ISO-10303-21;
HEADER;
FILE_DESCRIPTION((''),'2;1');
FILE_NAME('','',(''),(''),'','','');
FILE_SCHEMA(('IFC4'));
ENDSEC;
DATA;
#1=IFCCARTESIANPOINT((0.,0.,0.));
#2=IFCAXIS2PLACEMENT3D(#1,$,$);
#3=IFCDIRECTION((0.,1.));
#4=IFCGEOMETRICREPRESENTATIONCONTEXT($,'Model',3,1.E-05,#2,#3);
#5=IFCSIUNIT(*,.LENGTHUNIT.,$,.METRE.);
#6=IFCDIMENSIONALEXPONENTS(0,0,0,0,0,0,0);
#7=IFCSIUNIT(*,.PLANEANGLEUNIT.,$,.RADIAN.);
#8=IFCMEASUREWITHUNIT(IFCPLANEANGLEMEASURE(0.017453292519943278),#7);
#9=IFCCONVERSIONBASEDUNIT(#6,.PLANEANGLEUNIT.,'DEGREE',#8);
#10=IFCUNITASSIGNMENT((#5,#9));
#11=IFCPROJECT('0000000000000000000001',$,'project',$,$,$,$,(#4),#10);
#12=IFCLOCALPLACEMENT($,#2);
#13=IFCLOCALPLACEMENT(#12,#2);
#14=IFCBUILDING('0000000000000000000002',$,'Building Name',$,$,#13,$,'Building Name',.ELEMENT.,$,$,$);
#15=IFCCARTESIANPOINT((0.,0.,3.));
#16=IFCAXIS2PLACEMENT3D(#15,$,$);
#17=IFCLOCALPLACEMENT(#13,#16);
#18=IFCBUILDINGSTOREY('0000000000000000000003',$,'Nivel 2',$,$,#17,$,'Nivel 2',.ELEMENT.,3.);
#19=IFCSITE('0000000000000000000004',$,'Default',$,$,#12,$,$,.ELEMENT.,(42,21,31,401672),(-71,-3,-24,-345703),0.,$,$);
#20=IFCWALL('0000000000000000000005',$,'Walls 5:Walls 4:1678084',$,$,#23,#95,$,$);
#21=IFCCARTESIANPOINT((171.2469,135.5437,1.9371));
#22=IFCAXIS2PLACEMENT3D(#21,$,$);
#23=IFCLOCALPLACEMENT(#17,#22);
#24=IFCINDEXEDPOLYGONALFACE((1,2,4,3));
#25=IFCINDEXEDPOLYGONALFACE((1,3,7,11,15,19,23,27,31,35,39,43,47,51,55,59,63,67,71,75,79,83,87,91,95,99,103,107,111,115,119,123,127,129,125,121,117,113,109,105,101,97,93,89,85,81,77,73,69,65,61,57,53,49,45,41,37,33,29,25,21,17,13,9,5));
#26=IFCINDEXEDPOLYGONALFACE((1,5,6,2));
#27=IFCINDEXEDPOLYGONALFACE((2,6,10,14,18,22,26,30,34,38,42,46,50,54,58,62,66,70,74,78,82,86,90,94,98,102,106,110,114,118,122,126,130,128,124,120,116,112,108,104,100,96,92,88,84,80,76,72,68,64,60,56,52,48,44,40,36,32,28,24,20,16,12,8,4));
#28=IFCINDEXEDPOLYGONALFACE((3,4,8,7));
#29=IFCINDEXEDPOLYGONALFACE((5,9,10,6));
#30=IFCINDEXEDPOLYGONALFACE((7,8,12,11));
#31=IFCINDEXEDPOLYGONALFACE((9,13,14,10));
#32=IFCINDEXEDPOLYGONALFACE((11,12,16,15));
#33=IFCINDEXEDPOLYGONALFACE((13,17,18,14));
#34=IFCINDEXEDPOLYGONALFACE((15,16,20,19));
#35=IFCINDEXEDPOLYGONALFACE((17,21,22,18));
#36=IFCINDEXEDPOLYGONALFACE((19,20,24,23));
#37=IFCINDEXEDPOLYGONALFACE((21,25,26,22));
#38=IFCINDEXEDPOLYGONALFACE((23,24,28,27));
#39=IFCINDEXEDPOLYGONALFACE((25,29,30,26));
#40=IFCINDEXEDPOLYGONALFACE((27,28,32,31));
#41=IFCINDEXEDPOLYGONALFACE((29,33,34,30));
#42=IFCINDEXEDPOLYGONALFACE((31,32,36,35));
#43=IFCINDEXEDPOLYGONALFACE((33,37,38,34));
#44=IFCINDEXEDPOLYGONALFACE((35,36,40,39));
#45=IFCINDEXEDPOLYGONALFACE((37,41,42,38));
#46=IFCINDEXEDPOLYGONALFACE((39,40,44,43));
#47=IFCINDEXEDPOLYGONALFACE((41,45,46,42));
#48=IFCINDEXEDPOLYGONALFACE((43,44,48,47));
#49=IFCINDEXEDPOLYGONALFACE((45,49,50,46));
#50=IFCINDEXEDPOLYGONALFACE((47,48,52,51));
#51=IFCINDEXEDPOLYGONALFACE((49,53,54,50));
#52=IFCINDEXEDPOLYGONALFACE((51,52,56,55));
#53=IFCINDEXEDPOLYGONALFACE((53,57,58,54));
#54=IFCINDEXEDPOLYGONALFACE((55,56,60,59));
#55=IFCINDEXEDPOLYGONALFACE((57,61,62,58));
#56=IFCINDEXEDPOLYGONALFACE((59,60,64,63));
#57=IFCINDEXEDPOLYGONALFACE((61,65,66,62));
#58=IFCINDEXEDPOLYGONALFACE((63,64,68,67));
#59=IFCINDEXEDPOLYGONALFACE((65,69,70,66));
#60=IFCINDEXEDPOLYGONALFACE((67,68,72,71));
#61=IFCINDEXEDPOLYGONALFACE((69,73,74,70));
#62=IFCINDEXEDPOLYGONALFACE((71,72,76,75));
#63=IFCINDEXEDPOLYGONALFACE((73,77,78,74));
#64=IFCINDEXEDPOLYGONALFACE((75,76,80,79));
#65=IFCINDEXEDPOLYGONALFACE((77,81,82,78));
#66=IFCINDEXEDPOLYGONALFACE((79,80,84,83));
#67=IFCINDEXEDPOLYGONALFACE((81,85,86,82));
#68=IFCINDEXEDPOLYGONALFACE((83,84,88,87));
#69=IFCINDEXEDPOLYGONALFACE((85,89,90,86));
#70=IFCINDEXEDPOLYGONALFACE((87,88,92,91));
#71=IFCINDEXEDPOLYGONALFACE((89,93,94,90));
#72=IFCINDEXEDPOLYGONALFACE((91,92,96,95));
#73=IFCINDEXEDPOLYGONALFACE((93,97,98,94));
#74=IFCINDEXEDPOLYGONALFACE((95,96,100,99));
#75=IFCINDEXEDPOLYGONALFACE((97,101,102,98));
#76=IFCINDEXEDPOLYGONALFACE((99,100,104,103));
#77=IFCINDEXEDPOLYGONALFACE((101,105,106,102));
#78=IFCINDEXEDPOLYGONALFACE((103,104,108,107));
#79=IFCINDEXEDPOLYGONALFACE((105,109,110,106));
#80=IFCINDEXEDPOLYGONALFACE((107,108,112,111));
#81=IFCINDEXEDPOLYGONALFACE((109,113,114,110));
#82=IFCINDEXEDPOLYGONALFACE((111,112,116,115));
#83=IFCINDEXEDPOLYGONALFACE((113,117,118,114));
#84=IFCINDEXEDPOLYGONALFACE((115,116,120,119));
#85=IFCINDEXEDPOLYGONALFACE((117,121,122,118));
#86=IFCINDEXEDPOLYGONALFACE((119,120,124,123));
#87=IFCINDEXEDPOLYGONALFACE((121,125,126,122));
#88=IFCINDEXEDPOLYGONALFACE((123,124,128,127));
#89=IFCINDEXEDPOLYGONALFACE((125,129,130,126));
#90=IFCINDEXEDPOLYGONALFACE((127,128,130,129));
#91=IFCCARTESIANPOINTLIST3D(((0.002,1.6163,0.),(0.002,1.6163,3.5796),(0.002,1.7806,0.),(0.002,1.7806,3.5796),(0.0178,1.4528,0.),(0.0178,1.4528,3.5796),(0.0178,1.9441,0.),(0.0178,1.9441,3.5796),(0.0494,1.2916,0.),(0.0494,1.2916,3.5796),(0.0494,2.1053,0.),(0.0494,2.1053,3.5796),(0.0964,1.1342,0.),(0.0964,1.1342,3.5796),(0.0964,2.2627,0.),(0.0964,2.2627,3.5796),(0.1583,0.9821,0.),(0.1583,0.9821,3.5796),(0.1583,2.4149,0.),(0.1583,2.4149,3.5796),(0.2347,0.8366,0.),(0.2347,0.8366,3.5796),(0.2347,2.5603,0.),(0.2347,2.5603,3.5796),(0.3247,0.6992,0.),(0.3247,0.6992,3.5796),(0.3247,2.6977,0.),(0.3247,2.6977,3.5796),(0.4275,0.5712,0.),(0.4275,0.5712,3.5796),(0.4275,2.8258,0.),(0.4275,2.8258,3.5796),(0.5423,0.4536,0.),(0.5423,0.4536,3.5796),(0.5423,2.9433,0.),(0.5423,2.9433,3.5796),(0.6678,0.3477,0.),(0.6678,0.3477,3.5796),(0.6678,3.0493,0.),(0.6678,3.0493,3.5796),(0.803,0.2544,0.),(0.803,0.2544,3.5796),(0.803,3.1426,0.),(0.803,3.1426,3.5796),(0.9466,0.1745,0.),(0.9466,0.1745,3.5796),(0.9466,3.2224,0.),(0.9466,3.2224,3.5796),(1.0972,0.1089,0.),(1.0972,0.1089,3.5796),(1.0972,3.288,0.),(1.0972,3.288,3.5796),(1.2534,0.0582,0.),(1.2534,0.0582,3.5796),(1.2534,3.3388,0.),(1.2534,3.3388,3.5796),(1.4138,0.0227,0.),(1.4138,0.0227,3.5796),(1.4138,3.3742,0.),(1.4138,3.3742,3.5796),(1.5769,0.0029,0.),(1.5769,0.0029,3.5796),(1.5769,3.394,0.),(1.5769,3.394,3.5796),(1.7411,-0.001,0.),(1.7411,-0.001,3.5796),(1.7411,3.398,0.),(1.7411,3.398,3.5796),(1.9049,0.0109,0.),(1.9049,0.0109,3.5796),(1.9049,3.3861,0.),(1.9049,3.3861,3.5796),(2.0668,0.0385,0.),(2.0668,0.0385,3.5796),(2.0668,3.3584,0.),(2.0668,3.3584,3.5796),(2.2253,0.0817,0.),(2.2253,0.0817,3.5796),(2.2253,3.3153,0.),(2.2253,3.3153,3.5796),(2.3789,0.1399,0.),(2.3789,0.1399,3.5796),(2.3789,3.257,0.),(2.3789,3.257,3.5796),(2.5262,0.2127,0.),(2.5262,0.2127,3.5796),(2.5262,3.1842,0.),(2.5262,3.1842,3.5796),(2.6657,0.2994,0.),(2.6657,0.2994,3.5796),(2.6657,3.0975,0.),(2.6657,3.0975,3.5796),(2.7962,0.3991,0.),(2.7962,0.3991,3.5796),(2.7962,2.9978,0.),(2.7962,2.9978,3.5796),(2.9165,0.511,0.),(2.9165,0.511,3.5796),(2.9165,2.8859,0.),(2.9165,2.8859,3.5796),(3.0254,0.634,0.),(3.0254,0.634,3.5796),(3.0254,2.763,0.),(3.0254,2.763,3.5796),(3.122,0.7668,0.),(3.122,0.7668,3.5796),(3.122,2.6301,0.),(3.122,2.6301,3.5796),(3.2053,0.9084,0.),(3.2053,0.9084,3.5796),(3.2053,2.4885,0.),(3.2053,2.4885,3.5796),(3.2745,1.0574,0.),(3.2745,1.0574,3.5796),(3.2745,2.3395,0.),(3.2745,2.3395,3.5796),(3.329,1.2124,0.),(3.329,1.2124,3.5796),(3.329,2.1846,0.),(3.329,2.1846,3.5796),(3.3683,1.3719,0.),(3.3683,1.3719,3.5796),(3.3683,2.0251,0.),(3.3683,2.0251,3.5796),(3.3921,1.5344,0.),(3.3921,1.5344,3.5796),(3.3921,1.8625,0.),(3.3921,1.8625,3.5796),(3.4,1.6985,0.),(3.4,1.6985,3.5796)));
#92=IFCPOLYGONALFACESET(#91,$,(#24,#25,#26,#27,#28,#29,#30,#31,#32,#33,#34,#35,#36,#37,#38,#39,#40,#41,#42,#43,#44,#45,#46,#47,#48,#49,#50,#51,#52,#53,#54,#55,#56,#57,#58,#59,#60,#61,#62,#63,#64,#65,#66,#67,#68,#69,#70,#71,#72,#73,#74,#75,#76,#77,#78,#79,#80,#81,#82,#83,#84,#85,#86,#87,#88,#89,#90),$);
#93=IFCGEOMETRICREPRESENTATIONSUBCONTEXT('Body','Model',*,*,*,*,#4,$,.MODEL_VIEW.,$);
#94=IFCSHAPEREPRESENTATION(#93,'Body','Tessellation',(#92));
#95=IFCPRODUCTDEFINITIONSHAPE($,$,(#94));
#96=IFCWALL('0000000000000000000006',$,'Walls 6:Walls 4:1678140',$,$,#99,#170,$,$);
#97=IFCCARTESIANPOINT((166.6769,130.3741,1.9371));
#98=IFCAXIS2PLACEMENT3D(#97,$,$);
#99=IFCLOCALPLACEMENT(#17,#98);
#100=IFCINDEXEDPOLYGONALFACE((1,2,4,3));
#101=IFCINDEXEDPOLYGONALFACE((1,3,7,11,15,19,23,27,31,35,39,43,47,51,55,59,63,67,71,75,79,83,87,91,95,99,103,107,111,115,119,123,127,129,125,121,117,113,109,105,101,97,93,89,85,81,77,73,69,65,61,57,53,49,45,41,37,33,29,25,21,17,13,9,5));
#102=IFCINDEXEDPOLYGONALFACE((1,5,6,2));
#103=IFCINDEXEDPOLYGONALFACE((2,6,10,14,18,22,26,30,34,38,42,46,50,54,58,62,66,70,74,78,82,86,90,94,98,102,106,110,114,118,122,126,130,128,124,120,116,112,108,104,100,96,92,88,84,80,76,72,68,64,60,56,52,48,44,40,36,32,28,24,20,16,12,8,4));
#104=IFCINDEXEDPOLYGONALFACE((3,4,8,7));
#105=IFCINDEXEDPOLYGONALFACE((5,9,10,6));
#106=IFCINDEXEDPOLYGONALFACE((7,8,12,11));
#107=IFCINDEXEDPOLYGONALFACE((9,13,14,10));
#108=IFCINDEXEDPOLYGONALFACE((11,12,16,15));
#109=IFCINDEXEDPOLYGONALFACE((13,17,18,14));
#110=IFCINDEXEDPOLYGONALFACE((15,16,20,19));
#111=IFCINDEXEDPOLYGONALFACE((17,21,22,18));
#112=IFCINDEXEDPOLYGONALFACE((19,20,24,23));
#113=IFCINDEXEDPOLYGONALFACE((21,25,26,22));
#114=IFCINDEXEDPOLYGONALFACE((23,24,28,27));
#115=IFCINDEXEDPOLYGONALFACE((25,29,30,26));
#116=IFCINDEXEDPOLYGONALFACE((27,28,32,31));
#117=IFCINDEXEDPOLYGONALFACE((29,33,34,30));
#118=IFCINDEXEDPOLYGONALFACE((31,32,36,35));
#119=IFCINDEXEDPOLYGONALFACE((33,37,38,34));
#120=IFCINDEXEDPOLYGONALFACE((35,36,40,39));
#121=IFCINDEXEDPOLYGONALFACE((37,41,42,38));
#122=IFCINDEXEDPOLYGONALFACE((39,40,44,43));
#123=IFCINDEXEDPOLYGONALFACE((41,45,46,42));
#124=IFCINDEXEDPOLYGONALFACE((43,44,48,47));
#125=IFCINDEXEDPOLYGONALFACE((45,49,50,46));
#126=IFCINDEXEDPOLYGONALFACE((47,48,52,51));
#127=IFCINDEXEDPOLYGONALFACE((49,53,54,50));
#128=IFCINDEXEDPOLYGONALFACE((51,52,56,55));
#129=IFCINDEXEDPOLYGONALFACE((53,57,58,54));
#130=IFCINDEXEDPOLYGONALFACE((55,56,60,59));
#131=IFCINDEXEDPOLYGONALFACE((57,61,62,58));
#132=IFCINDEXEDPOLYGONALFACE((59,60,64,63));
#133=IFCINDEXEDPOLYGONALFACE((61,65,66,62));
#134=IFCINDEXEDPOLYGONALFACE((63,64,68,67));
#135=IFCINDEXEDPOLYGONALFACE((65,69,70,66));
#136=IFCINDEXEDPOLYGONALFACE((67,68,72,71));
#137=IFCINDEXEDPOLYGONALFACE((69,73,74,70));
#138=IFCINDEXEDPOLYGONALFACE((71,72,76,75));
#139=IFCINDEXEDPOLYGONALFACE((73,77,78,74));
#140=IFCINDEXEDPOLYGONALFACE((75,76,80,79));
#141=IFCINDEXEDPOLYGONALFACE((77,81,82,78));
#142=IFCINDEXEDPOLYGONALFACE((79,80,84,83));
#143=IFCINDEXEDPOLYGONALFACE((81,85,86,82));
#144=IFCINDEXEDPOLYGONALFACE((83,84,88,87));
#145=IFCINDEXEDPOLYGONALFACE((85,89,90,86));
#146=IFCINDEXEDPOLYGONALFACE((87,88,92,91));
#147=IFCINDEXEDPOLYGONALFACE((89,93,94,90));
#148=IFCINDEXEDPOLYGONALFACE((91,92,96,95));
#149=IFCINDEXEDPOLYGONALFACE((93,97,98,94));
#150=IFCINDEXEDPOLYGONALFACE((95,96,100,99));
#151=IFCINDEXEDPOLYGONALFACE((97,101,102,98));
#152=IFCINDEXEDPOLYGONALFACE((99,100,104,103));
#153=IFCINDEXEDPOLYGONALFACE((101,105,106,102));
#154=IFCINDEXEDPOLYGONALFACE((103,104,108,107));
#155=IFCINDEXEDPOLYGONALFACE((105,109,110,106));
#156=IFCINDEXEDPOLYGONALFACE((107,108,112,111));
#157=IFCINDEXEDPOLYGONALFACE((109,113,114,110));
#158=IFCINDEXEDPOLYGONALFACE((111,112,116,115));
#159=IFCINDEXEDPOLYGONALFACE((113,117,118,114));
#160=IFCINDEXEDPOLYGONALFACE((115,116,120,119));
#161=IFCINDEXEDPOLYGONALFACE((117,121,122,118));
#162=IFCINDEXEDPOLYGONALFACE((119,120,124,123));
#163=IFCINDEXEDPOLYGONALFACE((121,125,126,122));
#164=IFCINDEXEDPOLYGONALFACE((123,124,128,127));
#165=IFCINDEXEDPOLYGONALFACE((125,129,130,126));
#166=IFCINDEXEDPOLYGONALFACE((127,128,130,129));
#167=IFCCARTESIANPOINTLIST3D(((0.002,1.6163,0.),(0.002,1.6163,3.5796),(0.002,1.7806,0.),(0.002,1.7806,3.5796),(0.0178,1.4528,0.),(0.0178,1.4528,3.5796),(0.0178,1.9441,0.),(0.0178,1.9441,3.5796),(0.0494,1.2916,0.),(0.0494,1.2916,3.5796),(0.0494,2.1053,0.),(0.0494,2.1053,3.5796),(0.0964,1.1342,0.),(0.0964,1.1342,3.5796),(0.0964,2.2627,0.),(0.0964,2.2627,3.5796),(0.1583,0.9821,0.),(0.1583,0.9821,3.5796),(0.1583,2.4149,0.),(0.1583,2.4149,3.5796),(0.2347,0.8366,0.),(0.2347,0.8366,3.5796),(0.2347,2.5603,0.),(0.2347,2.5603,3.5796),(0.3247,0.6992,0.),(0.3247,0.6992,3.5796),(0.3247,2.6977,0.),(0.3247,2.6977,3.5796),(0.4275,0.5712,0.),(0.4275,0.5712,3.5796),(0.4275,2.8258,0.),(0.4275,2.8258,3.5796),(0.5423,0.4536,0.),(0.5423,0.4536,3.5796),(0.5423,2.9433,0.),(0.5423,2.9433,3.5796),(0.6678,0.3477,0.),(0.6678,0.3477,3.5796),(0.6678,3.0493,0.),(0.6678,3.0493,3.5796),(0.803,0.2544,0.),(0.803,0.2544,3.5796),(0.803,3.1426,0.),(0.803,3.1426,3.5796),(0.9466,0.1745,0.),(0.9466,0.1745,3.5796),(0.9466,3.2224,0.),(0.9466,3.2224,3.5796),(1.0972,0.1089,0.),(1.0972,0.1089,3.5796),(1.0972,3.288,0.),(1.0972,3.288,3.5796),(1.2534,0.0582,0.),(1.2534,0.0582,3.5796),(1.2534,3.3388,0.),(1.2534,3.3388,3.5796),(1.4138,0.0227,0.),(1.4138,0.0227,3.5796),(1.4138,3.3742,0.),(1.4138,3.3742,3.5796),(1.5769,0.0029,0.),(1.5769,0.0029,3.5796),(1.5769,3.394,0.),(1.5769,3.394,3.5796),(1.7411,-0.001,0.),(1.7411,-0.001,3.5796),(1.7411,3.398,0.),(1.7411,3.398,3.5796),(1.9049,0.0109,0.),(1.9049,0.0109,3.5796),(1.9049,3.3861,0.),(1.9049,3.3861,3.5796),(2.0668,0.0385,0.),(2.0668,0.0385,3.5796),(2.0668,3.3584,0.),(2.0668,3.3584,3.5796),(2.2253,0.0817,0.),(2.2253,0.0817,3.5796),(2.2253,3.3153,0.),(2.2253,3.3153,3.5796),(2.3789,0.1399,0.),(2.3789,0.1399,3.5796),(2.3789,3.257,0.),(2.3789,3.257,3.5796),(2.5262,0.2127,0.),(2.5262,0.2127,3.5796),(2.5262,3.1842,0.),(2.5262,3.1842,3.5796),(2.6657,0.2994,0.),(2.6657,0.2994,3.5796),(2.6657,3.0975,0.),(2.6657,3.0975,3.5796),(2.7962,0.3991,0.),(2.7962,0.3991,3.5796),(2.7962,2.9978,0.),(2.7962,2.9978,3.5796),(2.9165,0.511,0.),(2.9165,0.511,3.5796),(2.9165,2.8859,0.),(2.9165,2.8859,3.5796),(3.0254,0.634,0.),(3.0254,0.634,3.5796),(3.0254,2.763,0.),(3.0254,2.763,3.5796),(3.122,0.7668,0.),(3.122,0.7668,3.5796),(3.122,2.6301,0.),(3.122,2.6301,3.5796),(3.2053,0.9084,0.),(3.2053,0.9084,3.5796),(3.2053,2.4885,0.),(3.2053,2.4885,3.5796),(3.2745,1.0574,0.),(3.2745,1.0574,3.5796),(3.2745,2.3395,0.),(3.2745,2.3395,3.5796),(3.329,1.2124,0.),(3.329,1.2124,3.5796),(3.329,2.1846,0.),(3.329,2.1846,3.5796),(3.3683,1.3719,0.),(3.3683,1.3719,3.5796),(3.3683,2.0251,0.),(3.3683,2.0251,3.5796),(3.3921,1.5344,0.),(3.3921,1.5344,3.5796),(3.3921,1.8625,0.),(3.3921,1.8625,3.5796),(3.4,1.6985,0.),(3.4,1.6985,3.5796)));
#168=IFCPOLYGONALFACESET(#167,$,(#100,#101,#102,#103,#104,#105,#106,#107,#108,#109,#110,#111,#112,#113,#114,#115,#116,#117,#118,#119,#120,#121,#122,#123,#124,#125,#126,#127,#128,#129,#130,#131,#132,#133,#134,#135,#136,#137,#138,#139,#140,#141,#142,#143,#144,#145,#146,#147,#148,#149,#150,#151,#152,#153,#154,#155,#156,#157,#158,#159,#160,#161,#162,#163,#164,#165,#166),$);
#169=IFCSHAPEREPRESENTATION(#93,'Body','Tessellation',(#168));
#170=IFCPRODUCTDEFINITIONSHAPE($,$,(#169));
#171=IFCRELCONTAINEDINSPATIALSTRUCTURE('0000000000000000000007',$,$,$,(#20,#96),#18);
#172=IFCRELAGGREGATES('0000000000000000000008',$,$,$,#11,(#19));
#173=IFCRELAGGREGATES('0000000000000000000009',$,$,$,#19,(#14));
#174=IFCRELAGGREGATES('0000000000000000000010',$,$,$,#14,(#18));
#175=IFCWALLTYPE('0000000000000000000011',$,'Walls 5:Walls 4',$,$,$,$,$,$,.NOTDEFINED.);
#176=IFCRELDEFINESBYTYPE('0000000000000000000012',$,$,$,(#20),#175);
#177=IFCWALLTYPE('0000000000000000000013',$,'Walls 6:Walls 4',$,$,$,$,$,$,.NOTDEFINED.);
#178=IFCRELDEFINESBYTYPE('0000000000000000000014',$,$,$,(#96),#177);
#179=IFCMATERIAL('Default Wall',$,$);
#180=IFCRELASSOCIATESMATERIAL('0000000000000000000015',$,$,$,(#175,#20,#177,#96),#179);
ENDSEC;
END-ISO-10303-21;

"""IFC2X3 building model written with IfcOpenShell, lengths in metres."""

from ifc_helpers import new_model, entity, si_unit, converted_unit, direction, frame, origin, origin_2d_with_axis, place, context, subcontext, project, spatial, circle, extrude, material, type_object, element, save


model = new_model("IFC2X3")

# Units and contexts
model_context = context("Model", 3, precision=1e-05, world=origin(), true_north=direction((0.0, 1.0)))
body_context = subcontext(model_context, "Body", "Model", "MODEL_VIEW")
ifc_project = project(units=[si_unit("LENGTHUNIT", "METRE"), converted_unit("PLANEANGLEUNIT", "DEGREE", entity("IfcPlaneAngleMeasure", 0.017453292519943278), si_unit("PLANEANGLEUNIT", "RADIAN"), dimensions=[0, 0, 0, 0, 0, 0, 0])], contexts=[model_context])

# Site, building, storey
site_placement = place(None, origin())
site = spatial("IfcSite", under=ifc_project, at=site_placement, Name="Default", CompositionType="ELEMENT", RefLatitude=(42, 21, 31, 401672), RefLongitude=(-71, -3, -24, -345703), RefElevation=0.0)
building_placement = place(site_placement, origin())
building = spatial("IfcBuilding", under=site, at=building_placement, Name="Building Name", LongName="Building Name", CompositionType="ELEMENT")
storey_placement = place(building_placement, frame((0.0, 0.0, 3.0)))
storey = spatial("IfcBuildingStorey", under=building, at=storey_placement, Name="Nivel 2", LongName="Nivel 2", CompositionType="ELEMENT", Elevation=3.0)

# Walls
ifc_material_1 = material(Name="Default Wall")
wall_type_1 = type_object("IfcWallType", Name="Walls 5:Walls 4", PredefinedType="NOTDEFINED", material=ifc_material_1)
wall_1_placement = place(storey_placement, frame((171.2469, 135.5437, 1.9371)))
element("IfcWall", 1, at=wall_1_placement, inside=storey, type_object=wall_type_1, material=ifc_material_1, Name="Walls 5:Walls 4:1678084", context=body_context, shape_type="SweptSolid", body=[
    extrude(circle(Radius=1.7, at=origin_2d_with_axis()), frame((1.7, 1.6985, 0.0)), (0.0, 0.0, 1.0), 3.5796),
])
wall_type_2 = type_object("IfcWallType", Name="Walls 6:Walls 4", PredefinedType="NOTDEFINED", material=ifc_material_1)
wall_2_placement = place(storey_placement, frame((166.6769, 130.3741, 1.9371)))
element("IfcWall", 2, at=wall_2_placement, inside=storey, type_object=wall_type_2, material=ifc_material_1, Name="Walls 6:Walls 4:1678140", context=body_context, shape_type="SweptSolid", body=[
    extrude(circle(Radius=1.7, at=origin_2d_with_axis()), frame((1.7, 1.6985, 0.0)), (0.0, 0.0, 1.0), 3.5796),
])

save(model, "model.ifc")
